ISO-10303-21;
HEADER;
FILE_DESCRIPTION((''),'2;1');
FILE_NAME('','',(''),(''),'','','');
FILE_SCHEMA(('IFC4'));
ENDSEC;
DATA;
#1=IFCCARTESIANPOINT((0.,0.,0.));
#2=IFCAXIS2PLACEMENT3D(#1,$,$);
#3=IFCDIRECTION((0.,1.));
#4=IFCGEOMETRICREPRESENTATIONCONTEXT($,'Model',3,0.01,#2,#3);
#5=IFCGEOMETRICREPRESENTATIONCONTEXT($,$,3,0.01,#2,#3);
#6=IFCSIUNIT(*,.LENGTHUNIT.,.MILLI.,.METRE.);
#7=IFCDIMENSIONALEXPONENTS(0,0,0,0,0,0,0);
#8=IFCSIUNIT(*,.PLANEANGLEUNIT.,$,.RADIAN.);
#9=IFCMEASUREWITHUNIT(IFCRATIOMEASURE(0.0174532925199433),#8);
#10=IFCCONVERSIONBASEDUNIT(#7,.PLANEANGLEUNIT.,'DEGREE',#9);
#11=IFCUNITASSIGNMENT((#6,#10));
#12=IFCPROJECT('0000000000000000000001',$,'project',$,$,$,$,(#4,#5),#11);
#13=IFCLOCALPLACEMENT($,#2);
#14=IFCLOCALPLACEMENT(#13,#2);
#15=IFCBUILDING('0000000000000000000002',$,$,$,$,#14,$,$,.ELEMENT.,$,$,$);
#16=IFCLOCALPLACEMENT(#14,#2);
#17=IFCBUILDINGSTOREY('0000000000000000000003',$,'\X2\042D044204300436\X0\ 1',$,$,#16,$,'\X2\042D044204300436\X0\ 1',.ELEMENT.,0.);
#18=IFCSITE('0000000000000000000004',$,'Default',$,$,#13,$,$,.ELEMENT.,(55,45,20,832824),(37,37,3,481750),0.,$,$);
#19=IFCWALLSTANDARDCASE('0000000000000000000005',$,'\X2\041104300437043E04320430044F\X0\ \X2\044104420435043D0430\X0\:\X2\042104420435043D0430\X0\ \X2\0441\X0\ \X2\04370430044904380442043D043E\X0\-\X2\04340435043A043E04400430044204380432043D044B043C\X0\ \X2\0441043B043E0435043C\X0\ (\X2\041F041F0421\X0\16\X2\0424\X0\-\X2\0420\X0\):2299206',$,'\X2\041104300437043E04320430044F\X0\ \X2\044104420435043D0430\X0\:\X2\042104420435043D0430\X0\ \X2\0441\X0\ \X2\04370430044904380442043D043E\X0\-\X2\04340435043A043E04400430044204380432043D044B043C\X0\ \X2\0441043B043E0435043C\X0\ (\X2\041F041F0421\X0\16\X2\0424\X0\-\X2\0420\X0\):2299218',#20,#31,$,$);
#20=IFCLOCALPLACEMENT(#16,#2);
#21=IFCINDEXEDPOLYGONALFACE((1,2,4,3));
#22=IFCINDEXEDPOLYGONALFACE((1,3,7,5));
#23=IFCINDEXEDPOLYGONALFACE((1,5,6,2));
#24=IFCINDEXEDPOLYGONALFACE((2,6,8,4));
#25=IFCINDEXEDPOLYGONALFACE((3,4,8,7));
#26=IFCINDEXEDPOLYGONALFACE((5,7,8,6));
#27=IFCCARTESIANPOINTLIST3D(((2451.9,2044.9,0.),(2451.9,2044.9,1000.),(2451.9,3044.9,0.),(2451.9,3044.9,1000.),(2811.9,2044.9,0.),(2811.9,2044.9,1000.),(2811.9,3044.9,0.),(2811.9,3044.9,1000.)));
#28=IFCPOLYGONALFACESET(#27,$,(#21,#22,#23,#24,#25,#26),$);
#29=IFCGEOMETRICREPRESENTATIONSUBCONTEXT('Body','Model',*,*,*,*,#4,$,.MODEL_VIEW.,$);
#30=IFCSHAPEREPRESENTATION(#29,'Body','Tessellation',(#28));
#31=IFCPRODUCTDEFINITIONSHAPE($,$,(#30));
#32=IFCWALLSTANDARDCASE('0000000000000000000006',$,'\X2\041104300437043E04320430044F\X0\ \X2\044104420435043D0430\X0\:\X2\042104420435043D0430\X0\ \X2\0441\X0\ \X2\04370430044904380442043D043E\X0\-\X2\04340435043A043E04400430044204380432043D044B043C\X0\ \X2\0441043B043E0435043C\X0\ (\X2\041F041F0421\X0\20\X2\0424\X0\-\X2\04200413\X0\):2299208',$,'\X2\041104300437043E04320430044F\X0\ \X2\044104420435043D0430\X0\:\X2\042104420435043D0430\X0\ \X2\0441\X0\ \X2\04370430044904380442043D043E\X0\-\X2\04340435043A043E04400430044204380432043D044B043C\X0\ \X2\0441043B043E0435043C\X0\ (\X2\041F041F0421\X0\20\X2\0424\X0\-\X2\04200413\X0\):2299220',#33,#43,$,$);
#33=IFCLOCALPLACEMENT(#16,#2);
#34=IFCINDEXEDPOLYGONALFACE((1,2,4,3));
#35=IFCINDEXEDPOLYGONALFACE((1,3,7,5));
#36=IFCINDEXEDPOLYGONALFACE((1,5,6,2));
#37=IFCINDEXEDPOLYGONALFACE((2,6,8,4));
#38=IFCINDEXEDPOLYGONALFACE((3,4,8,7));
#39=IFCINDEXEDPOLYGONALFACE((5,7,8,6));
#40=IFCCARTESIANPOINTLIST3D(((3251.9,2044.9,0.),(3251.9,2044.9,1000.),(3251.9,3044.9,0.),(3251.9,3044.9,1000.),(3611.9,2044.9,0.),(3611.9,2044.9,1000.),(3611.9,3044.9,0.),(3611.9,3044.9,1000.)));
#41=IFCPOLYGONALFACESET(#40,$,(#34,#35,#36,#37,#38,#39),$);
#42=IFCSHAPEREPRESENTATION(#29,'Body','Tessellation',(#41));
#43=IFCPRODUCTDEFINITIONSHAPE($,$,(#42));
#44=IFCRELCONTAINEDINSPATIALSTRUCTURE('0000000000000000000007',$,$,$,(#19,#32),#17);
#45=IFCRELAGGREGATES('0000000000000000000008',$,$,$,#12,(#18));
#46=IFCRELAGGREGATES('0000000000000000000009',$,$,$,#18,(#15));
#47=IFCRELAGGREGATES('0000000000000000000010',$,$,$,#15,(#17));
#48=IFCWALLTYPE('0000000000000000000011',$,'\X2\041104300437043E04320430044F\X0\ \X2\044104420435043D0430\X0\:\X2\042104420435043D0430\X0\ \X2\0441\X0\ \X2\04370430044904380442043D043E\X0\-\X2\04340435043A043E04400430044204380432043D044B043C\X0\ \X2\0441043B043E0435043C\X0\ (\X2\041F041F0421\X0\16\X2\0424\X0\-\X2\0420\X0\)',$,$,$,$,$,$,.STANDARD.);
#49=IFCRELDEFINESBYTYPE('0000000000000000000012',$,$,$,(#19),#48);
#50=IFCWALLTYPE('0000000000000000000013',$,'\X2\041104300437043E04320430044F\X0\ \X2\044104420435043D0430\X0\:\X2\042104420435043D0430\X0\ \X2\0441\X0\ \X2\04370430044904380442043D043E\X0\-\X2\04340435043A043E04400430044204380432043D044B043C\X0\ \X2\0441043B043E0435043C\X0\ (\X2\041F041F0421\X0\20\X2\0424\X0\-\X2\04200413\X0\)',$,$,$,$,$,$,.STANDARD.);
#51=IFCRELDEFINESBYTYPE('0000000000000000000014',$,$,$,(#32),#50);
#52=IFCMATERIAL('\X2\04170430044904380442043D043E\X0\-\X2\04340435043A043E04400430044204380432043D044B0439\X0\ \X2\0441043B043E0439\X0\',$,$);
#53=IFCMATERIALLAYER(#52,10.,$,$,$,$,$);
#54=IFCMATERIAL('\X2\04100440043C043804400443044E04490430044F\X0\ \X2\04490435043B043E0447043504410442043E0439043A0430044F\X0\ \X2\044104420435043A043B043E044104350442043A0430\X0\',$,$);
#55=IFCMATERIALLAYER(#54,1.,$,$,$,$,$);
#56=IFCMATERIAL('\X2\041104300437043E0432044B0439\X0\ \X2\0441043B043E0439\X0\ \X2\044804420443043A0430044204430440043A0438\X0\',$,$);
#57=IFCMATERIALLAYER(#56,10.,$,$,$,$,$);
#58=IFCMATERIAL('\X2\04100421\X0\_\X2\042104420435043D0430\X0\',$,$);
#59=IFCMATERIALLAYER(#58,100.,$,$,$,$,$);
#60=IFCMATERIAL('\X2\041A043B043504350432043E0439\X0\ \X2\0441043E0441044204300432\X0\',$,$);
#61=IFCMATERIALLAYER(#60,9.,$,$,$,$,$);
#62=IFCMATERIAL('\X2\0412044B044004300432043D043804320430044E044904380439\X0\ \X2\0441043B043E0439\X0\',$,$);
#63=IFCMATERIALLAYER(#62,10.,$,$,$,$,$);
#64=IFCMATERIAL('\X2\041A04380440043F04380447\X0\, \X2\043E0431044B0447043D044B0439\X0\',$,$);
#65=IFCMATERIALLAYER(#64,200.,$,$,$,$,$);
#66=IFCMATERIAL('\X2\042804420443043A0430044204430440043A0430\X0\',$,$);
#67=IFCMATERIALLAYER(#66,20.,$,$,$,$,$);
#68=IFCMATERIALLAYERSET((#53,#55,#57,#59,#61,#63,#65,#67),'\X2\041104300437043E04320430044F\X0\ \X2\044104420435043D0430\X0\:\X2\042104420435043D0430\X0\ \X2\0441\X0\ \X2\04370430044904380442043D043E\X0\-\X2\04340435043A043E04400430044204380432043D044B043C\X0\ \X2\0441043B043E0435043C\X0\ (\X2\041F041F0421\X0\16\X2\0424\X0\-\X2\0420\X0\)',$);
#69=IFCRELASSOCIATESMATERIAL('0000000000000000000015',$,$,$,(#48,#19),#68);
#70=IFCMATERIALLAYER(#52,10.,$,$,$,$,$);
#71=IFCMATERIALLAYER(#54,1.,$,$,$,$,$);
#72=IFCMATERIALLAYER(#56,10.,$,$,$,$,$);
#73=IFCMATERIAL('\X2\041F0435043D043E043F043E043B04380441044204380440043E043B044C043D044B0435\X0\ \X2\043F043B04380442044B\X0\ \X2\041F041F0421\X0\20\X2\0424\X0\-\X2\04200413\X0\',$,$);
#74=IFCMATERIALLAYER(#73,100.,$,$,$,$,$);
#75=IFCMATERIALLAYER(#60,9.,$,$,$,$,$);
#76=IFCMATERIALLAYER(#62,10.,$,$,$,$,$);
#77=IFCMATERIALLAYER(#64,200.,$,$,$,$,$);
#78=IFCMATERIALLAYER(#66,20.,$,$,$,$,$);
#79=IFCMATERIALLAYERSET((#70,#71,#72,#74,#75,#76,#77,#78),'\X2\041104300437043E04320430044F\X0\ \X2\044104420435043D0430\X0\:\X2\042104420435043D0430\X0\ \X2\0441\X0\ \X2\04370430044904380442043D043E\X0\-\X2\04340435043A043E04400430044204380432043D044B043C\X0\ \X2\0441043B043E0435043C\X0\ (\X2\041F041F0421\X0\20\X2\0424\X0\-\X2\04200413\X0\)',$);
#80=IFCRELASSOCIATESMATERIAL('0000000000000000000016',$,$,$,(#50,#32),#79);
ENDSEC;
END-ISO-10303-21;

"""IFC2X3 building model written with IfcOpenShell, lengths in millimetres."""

from ifc_helpers import new_model, entity, si_unit, converted_unit, direction, frame, frame_2d, origin, place, context, subcontext, project, spatial, rectangle, extrude, material, layer, layer_set, layer_usage, type_object, element, save


model = new_model("IFC2X3")

# Units and contexts
model_context = context("Model", 3, precision=0.01, world=origin(), true_north=direction((0.0, 1.0)))
context_of_model = context(None, 3, precision=0.01, world=origin(), true_north=direction((0.0, 1.0)))
body_context = subcontext(model_context, "Body", "Model", "MODEL_VIEW")
ifc_project = project(units=[si_unit("LENGTHUNIT", "METRE", prefix="MILLI"), converted_unit("PLANEANGLEUNIT", "DEGREE", entity("IfcRatioMeasure", 0.0174532925199433), si_unit("PLANEANGLEUNIT", "RADIAN"), dimensions=[0, 0, 0, 0, 0, 0, 0])], contexts=[model_context, context_of_model])

# Site, building, storey
site_placement = place(None, origin())
site = spatial("IfcSite", under=ifc_project, at=site_placement, Name="Default", CompositionType="ELEMENT", RefLatitude=(55, 45, 20, 832824), RefLongitude=(37, 37, 3, 481750), RefElevation=0.0)
building_placement = place(site_placement, origin())
building = spatial("IfcBuilding", under=site, at=building_placement, CompositionType="ELEMENT")
storey_placement = place(building_placement, origin())
storey = spatial("IfcBuildingStorey", under=building, at=storey_placement, Name="Этаж 1", LongName="Этаж 1", CompositionType="ELEMENT", Elevation=0.0)

# Walls
ifc_material_1 = material(Name="Защитно-декоративный слой")
ifc_layer_1 = layer(ifc_material_1, 10.0)
ifc_material_2 = material(Name="Армирующая щелочестойкая стеклосетка")
ifc_layer_2 = layer(ifc_material_2, 1.0)
ifc_material_3 = material(Name="Базовый слой штукатурки")
ifc_layer_3 = layer(ifc_material_3, 10.0)
ifc_material_4 = material(Name="АС_Стена")
ifc_layer_4 = layer(ifc_material_4, 100.0)
ifc_material_5 = material(Name="Клеевой состав")
ifc_layer_5 = layer(ifc_material_5, 9.0)
ifc_material_6 = material(Name="Выравнивающий слой")
ifc_layer_6 = layer(ifc_material_6, 10.0)
ifc_material_7 = material(Name="Кирпич, обычный")
ifc_layer_7 = layer(ifc_material_7, 200.0)
ifc_material_8 = material(Name="Штукатурка")
ifc_layer_8 = layer(ifc_material_8, 20.0)
ifc_layer_set_1 = layer_set([ifc_layer_1, ifc_layer_2, ifc_layer_3, ifc_layer_4, ifc_layer_5, ifc_layer_6, ifc_layer_7, ifc_layer_8], Name="Базовая стена:Стена с защитно-декоративным слоем (ППС16Ф-Р)")
ifc_layer_usage_1 = layer_usage(ifc_layer_set_1, "AXIS2", "POSITIVE", -180.0)
wall_type_1 = type_object("IfcWallType", Name="Базовая стена:Стена с защитно-декоративным слоем (ППС16Ф-Р)", PredefinedType="STANDARD", material=ifc_layer_set_1)
wall_1_placement = place(storey_placement, frame((2631.9, 3044.9, 0.0), z_axis=(0.0, 0.0, 1.0), x_axis=(0.0, -1.0, 0.0)))
element("IfcWallStandardCase", 1, at=wall_1_placement, inside=storey, type_object=wall_type_1, material=ifc_layer_usage_1, Name="Базовая стена:Стена с защитно-декоративным слоем (ППС16Ф-Р):2299206", ObjectType="Базовая стена:Стена с защитно-декоративным слоем (ППС16Ф-Р):2299218", context=body_context, shape_type="SweptSolid", body=[
    extrude(rectangle(XDim=1000.0, YDim=360.0, at=frame_2d((500.0, 0.0), x_axis=(-1.0, 0.0))), origin(), (0.0, 0.0, 1.0), 1000.0),
])
ifc_layer_9 = layer(ifc_material_1, 10.0)
ifc_layer_10 = layer(ifc_material_2, 1.0)
ifc_layer_11 = layer(ifc_material_3, 10.0)
ifc_material_9 = material(Name="Пенополистирольные плиты ППС20Ф-РГ")
ifc_layer_12 = layer(ifc_material_9, 100.0)
ifc_layer_13 = layer(ifc_material_5, 9.0)
ifc_layer_14 = layer(ifc_material_6, 10.0)
ifc_layer_15 = layer(ifc_material_7, 200.0)
ifc_layer_16 = layer(ifc_material_8, 20.0)
ifc_layer_set_2 = layer_set([ifc_layer_9, ifc_layer_10, ifc_layer_11, ifc_layer_12, ifc_layer_13, ifc_layer_14, ifc_layer_15, ifc_layer_16], Name="Базовая стена:Стена с защитно-декоративным слоем (ППС20Ф-РГ)")
ifc_layer_usage_2 = layer_usage(ifc_layer_set_2, "AXIS2", "POSITIVE", -180.0)
wall_type_2 = type_object("IfcWallType", Name="Базовая стена:Стена с защитно-декоративным слоем (ППС20Ф-РГ)", PredefinedType="STANDARD", material=ifc_layer_set_2)
wall_2_placement = place(storey_placement, frame((3431.9, 3044.9, 0.0), z_axis=(0.0, 0.0, 1.0), x_axis=(0.0, -1.0, 0.0)))
element("IfcWallStandardCase", 2, at=wall_2_placement, inside=storey, type_object=wall_type_2, material=ifc_layer_usage_2, Name="Базовая стена:Стена с защитно-декоративным слоем (ППС20Ф-РГ):2299208", ObjectType="Базовая стена:Стена с защитно-декоративным слоем (ППС20Ф-РГ):2299220", context=body_context, shape_type="SweptSolid", body=[
    extrude(rectangle(XDim=1000.0, YDim=360.0, at=frame_2d((500.0, 0.0), x_axis=(-1.0, 0.0))), origin(), (0.0, 0.0, 1.0), 1000.0),
])

save(model, "model.ifc")
